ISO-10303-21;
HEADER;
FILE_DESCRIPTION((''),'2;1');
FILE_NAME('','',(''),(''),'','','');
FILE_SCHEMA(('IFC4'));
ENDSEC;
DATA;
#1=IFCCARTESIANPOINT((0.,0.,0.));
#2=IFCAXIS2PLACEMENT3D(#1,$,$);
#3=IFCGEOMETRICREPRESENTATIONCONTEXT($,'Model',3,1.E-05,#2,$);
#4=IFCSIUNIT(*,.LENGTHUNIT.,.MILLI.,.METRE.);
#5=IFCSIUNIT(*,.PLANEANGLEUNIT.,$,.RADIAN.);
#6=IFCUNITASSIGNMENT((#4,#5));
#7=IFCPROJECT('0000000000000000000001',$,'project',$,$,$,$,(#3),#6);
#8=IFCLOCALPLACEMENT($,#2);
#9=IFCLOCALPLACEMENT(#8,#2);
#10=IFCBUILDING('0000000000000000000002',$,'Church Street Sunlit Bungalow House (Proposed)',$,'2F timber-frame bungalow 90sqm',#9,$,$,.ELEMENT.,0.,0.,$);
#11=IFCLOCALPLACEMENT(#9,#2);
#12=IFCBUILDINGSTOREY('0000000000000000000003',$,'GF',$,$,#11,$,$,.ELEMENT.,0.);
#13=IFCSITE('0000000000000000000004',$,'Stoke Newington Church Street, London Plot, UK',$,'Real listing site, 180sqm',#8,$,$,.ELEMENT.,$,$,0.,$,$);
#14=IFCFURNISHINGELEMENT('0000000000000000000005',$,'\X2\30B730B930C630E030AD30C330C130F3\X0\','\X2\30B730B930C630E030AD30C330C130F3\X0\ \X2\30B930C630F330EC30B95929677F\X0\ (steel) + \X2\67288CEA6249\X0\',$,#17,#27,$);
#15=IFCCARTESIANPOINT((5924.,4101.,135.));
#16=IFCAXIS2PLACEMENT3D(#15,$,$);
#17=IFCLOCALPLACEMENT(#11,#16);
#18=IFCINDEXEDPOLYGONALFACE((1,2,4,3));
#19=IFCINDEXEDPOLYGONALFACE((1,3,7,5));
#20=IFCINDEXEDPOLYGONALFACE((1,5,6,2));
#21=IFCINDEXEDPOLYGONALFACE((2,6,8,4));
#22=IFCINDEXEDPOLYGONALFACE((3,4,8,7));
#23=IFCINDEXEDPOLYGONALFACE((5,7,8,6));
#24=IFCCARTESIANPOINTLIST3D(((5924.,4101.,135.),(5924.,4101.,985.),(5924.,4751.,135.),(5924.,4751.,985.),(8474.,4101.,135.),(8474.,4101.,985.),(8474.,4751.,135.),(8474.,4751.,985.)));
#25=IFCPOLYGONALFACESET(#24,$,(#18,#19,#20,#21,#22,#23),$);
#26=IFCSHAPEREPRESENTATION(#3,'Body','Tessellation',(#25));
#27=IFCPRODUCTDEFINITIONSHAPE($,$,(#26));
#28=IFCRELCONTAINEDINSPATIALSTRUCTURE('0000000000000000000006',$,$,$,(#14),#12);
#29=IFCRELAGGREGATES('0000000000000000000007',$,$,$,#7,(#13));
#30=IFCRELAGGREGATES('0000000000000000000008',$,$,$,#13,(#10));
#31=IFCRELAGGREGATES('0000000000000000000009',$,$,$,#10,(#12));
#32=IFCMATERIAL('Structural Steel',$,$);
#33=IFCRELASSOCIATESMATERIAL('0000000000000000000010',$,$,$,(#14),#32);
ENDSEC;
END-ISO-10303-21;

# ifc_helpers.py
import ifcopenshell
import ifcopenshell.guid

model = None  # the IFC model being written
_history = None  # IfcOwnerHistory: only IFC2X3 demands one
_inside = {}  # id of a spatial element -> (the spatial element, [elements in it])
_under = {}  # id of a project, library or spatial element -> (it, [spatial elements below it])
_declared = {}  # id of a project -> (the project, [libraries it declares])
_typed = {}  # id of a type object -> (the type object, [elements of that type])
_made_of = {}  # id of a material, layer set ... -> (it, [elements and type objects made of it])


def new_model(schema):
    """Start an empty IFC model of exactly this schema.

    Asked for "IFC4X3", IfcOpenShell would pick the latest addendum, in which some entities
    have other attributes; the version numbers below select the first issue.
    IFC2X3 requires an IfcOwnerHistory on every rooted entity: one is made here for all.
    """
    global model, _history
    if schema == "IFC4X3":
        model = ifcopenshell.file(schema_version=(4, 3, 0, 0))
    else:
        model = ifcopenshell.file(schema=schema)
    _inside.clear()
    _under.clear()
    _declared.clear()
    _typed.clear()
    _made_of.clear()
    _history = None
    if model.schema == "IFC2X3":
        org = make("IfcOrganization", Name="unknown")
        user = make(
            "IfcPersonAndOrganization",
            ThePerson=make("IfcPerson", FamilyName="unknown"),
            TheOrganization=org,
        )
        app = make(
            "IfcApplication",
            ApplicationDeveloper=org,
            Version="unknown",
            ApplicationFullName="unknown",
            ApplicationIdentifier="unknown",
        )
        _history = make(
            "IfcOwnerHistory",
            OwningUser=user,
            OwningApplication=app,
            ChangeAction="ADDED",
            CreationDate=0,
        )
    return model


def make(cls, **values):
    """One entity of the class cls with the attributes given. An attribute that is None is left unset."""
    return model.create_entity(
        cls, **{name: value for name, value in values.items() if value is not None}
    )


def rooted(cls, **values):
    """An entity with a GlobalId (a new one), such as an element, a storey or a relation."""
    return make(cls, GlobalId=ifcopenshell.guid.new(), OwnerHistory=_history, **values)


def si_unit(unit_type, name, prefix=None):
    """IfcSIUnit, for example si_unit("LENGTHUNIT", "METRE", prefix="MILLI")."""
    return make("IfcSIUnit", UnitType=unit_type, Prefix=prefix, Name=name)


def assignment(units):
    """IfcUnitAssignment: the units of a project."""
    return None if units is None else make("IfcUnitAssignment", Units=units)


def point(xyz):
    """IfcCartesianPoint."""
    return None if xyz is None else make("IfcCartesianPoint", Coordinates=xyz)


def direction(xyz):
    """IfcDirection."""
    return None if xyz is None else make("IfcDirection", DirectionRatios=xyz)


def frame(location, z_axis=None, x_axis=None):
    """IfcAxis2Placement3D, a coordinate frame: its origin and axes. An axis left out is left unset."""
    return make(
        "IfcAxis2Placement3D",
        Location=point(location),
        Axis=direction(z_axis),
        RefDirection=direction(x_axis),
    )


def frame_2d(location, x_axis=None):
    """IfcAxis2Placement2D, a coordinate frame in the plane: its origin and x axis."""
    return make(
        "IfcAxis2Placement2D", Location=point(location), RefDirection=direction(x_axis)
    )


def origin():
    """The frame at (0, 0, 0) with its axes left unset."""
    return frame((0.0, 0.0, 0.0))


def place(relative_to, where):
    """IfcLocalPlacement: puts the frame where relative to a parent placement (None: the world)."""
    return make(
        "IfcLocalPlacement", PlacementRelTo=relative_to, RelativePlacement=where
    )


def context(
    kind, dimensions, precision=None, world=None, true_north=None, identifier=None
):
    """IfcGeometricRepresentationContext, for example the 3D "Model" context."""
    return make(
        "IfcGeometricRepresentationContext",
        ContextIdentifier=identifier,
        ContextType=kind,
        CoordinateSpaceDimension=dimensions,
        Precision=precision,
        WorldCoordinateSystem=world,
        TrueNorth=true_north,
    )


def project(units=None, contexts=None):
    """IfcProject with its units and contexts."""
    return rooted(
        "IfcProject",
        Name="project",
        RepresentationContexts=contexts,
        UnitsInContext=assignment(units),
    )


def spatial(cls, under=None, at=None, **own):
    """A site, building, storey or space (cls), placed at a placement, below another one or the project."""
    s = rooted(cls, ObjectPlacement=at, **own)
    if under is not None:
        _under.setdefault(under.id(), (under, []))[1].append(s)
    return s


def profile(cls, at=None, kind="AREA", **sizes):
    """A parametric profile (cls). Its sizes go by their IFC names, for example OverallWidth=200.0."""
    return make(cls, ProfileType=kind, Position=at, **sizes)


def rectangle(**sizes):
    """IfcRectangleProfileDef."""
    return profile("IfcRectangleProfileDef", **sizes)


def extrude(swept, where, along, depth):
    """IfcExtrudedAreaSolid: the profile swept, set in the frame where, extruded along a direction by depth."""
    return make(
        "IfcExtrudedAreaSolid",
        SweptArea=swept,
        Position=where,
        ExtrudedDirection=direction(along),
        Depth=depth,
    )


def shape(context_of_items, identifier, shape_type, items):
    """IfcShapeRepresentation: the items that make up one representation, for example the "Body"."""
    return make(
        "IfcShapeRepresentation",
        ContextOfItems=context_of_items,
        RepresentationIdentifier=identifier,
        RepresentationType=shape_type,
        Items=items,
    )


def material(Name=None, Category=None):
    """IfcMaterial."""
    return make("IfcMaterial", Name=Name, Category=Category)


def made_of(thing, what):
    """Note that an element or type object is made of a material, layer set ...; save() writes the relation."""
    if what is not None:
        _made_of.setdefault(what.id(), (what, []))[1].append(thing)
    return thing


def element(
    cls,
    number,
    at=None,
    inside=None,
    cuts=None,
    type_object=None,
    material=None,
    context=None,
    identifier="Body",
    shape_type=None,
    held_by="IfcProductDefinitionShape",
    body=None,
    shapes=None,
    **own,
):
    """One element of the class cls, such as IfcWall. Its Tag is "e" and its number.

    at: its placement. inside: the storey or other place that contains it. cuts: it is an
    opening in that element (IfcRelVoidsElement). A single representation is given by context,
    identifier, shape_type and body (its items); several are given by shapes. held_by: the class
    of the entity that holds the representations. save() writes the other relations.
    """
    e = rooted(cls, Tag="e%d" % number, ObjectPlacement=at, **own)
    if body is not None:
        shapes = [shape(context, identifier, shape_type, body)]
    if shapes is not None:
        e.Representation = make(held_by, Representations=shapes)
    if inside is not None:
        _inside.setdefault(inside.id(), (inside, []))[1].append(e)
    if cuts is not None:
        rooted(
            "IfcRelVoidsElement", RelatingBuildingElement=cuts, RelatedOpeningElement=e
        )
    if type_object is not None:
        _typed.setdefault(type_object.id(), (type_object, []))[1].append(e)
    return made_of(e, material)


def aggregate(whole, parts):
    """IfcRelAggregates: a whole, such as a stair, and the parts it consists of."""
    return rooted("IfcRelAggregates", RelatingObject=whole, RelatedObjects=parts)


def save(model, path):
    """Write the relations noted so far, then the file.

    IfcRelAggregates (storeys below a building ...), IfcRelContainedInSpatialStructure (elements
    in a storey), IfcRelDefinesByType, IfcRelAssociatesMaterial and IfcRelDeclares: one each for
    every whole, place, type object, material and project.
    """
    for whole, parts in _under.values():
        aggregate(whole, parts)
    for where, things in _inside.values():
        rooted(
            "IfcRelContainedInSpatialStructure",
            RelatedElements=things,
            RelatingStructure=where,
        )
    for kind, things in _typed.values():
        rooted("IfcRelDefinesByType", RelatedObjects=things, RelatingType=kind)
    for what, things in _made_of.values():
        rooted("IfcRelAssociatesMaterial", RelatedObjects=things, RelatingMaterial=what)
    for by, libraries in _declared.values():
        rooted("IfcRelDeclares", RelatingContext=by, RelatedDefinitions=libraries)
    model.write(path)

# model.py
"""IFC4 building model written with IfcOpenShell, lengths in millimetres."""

from ifc_helpers import new_model, si_unit, frame, frame_2d, origin, place, context, project, spatial, rectangle, extrude, material, element, save


model = new_model("IFC4")

# Units and contexts
model_context = context("Model", 3, precision=1e-05, world=origin())
ifc_project = project(units=[si_unit("LENGTHUNIT", "METRE", prefix="MILLI"), si_unit("PLANEANGLEUNIT", "RADIAN")], contexts=[model_context])

# Site, building, storey
site_placement = place(None, origin())
site = spatial("IfcSite", under=ifc_project, at=site_placement, Name="Stoke Newington Church Street, London Plot, UK", ObjectType="Real listing site, 180sqm", CompositionType="ELEMENT", RefElevation=0.0)
building_placement = place(site_placement, origin())
building = spatial("IfcBuilding", under=site, at=building_placement, Name="Church Street Sunlit Bungalow House (Proposed)", ObjectType="2F timber-frame bungalow 90sqm", CompositionType="ELEMENT", ElevationOfRefHeight=0.0, ElevationOfTerrain=0.0)
storey_placement = place(building_placement, origin())
storey = spatial("IfcBuildingStorey", under=building, at=storey_placement, Name="GF", CompositionType="ELEMENT", Elevation=0.0)

# Furnishing element
ifc_material_1 = material(Name="Structural Steel")
furnishing_placement = place(storey_placement, frame((5924.0, 4101.0, 135.0)))
element("IfcFurnishingElement", 1, at=furnishing_placement, inside=storey, material=ifc_material_1, Name="システムキッチン", Description="システムキッチン ステンレス天板 (steel) + 木質扉", context=model_context, shape_type="SweptSolid", body=[
    extrude(rectangle(XDim=2550.0, YDim=650.0, at=frame_2d((1275.0, 325.0))), frame((5924.0, 4101.0, 135.0)), (0.0, 0.0, 1.0), 850.0),
])

save(model, "model.ifc")
